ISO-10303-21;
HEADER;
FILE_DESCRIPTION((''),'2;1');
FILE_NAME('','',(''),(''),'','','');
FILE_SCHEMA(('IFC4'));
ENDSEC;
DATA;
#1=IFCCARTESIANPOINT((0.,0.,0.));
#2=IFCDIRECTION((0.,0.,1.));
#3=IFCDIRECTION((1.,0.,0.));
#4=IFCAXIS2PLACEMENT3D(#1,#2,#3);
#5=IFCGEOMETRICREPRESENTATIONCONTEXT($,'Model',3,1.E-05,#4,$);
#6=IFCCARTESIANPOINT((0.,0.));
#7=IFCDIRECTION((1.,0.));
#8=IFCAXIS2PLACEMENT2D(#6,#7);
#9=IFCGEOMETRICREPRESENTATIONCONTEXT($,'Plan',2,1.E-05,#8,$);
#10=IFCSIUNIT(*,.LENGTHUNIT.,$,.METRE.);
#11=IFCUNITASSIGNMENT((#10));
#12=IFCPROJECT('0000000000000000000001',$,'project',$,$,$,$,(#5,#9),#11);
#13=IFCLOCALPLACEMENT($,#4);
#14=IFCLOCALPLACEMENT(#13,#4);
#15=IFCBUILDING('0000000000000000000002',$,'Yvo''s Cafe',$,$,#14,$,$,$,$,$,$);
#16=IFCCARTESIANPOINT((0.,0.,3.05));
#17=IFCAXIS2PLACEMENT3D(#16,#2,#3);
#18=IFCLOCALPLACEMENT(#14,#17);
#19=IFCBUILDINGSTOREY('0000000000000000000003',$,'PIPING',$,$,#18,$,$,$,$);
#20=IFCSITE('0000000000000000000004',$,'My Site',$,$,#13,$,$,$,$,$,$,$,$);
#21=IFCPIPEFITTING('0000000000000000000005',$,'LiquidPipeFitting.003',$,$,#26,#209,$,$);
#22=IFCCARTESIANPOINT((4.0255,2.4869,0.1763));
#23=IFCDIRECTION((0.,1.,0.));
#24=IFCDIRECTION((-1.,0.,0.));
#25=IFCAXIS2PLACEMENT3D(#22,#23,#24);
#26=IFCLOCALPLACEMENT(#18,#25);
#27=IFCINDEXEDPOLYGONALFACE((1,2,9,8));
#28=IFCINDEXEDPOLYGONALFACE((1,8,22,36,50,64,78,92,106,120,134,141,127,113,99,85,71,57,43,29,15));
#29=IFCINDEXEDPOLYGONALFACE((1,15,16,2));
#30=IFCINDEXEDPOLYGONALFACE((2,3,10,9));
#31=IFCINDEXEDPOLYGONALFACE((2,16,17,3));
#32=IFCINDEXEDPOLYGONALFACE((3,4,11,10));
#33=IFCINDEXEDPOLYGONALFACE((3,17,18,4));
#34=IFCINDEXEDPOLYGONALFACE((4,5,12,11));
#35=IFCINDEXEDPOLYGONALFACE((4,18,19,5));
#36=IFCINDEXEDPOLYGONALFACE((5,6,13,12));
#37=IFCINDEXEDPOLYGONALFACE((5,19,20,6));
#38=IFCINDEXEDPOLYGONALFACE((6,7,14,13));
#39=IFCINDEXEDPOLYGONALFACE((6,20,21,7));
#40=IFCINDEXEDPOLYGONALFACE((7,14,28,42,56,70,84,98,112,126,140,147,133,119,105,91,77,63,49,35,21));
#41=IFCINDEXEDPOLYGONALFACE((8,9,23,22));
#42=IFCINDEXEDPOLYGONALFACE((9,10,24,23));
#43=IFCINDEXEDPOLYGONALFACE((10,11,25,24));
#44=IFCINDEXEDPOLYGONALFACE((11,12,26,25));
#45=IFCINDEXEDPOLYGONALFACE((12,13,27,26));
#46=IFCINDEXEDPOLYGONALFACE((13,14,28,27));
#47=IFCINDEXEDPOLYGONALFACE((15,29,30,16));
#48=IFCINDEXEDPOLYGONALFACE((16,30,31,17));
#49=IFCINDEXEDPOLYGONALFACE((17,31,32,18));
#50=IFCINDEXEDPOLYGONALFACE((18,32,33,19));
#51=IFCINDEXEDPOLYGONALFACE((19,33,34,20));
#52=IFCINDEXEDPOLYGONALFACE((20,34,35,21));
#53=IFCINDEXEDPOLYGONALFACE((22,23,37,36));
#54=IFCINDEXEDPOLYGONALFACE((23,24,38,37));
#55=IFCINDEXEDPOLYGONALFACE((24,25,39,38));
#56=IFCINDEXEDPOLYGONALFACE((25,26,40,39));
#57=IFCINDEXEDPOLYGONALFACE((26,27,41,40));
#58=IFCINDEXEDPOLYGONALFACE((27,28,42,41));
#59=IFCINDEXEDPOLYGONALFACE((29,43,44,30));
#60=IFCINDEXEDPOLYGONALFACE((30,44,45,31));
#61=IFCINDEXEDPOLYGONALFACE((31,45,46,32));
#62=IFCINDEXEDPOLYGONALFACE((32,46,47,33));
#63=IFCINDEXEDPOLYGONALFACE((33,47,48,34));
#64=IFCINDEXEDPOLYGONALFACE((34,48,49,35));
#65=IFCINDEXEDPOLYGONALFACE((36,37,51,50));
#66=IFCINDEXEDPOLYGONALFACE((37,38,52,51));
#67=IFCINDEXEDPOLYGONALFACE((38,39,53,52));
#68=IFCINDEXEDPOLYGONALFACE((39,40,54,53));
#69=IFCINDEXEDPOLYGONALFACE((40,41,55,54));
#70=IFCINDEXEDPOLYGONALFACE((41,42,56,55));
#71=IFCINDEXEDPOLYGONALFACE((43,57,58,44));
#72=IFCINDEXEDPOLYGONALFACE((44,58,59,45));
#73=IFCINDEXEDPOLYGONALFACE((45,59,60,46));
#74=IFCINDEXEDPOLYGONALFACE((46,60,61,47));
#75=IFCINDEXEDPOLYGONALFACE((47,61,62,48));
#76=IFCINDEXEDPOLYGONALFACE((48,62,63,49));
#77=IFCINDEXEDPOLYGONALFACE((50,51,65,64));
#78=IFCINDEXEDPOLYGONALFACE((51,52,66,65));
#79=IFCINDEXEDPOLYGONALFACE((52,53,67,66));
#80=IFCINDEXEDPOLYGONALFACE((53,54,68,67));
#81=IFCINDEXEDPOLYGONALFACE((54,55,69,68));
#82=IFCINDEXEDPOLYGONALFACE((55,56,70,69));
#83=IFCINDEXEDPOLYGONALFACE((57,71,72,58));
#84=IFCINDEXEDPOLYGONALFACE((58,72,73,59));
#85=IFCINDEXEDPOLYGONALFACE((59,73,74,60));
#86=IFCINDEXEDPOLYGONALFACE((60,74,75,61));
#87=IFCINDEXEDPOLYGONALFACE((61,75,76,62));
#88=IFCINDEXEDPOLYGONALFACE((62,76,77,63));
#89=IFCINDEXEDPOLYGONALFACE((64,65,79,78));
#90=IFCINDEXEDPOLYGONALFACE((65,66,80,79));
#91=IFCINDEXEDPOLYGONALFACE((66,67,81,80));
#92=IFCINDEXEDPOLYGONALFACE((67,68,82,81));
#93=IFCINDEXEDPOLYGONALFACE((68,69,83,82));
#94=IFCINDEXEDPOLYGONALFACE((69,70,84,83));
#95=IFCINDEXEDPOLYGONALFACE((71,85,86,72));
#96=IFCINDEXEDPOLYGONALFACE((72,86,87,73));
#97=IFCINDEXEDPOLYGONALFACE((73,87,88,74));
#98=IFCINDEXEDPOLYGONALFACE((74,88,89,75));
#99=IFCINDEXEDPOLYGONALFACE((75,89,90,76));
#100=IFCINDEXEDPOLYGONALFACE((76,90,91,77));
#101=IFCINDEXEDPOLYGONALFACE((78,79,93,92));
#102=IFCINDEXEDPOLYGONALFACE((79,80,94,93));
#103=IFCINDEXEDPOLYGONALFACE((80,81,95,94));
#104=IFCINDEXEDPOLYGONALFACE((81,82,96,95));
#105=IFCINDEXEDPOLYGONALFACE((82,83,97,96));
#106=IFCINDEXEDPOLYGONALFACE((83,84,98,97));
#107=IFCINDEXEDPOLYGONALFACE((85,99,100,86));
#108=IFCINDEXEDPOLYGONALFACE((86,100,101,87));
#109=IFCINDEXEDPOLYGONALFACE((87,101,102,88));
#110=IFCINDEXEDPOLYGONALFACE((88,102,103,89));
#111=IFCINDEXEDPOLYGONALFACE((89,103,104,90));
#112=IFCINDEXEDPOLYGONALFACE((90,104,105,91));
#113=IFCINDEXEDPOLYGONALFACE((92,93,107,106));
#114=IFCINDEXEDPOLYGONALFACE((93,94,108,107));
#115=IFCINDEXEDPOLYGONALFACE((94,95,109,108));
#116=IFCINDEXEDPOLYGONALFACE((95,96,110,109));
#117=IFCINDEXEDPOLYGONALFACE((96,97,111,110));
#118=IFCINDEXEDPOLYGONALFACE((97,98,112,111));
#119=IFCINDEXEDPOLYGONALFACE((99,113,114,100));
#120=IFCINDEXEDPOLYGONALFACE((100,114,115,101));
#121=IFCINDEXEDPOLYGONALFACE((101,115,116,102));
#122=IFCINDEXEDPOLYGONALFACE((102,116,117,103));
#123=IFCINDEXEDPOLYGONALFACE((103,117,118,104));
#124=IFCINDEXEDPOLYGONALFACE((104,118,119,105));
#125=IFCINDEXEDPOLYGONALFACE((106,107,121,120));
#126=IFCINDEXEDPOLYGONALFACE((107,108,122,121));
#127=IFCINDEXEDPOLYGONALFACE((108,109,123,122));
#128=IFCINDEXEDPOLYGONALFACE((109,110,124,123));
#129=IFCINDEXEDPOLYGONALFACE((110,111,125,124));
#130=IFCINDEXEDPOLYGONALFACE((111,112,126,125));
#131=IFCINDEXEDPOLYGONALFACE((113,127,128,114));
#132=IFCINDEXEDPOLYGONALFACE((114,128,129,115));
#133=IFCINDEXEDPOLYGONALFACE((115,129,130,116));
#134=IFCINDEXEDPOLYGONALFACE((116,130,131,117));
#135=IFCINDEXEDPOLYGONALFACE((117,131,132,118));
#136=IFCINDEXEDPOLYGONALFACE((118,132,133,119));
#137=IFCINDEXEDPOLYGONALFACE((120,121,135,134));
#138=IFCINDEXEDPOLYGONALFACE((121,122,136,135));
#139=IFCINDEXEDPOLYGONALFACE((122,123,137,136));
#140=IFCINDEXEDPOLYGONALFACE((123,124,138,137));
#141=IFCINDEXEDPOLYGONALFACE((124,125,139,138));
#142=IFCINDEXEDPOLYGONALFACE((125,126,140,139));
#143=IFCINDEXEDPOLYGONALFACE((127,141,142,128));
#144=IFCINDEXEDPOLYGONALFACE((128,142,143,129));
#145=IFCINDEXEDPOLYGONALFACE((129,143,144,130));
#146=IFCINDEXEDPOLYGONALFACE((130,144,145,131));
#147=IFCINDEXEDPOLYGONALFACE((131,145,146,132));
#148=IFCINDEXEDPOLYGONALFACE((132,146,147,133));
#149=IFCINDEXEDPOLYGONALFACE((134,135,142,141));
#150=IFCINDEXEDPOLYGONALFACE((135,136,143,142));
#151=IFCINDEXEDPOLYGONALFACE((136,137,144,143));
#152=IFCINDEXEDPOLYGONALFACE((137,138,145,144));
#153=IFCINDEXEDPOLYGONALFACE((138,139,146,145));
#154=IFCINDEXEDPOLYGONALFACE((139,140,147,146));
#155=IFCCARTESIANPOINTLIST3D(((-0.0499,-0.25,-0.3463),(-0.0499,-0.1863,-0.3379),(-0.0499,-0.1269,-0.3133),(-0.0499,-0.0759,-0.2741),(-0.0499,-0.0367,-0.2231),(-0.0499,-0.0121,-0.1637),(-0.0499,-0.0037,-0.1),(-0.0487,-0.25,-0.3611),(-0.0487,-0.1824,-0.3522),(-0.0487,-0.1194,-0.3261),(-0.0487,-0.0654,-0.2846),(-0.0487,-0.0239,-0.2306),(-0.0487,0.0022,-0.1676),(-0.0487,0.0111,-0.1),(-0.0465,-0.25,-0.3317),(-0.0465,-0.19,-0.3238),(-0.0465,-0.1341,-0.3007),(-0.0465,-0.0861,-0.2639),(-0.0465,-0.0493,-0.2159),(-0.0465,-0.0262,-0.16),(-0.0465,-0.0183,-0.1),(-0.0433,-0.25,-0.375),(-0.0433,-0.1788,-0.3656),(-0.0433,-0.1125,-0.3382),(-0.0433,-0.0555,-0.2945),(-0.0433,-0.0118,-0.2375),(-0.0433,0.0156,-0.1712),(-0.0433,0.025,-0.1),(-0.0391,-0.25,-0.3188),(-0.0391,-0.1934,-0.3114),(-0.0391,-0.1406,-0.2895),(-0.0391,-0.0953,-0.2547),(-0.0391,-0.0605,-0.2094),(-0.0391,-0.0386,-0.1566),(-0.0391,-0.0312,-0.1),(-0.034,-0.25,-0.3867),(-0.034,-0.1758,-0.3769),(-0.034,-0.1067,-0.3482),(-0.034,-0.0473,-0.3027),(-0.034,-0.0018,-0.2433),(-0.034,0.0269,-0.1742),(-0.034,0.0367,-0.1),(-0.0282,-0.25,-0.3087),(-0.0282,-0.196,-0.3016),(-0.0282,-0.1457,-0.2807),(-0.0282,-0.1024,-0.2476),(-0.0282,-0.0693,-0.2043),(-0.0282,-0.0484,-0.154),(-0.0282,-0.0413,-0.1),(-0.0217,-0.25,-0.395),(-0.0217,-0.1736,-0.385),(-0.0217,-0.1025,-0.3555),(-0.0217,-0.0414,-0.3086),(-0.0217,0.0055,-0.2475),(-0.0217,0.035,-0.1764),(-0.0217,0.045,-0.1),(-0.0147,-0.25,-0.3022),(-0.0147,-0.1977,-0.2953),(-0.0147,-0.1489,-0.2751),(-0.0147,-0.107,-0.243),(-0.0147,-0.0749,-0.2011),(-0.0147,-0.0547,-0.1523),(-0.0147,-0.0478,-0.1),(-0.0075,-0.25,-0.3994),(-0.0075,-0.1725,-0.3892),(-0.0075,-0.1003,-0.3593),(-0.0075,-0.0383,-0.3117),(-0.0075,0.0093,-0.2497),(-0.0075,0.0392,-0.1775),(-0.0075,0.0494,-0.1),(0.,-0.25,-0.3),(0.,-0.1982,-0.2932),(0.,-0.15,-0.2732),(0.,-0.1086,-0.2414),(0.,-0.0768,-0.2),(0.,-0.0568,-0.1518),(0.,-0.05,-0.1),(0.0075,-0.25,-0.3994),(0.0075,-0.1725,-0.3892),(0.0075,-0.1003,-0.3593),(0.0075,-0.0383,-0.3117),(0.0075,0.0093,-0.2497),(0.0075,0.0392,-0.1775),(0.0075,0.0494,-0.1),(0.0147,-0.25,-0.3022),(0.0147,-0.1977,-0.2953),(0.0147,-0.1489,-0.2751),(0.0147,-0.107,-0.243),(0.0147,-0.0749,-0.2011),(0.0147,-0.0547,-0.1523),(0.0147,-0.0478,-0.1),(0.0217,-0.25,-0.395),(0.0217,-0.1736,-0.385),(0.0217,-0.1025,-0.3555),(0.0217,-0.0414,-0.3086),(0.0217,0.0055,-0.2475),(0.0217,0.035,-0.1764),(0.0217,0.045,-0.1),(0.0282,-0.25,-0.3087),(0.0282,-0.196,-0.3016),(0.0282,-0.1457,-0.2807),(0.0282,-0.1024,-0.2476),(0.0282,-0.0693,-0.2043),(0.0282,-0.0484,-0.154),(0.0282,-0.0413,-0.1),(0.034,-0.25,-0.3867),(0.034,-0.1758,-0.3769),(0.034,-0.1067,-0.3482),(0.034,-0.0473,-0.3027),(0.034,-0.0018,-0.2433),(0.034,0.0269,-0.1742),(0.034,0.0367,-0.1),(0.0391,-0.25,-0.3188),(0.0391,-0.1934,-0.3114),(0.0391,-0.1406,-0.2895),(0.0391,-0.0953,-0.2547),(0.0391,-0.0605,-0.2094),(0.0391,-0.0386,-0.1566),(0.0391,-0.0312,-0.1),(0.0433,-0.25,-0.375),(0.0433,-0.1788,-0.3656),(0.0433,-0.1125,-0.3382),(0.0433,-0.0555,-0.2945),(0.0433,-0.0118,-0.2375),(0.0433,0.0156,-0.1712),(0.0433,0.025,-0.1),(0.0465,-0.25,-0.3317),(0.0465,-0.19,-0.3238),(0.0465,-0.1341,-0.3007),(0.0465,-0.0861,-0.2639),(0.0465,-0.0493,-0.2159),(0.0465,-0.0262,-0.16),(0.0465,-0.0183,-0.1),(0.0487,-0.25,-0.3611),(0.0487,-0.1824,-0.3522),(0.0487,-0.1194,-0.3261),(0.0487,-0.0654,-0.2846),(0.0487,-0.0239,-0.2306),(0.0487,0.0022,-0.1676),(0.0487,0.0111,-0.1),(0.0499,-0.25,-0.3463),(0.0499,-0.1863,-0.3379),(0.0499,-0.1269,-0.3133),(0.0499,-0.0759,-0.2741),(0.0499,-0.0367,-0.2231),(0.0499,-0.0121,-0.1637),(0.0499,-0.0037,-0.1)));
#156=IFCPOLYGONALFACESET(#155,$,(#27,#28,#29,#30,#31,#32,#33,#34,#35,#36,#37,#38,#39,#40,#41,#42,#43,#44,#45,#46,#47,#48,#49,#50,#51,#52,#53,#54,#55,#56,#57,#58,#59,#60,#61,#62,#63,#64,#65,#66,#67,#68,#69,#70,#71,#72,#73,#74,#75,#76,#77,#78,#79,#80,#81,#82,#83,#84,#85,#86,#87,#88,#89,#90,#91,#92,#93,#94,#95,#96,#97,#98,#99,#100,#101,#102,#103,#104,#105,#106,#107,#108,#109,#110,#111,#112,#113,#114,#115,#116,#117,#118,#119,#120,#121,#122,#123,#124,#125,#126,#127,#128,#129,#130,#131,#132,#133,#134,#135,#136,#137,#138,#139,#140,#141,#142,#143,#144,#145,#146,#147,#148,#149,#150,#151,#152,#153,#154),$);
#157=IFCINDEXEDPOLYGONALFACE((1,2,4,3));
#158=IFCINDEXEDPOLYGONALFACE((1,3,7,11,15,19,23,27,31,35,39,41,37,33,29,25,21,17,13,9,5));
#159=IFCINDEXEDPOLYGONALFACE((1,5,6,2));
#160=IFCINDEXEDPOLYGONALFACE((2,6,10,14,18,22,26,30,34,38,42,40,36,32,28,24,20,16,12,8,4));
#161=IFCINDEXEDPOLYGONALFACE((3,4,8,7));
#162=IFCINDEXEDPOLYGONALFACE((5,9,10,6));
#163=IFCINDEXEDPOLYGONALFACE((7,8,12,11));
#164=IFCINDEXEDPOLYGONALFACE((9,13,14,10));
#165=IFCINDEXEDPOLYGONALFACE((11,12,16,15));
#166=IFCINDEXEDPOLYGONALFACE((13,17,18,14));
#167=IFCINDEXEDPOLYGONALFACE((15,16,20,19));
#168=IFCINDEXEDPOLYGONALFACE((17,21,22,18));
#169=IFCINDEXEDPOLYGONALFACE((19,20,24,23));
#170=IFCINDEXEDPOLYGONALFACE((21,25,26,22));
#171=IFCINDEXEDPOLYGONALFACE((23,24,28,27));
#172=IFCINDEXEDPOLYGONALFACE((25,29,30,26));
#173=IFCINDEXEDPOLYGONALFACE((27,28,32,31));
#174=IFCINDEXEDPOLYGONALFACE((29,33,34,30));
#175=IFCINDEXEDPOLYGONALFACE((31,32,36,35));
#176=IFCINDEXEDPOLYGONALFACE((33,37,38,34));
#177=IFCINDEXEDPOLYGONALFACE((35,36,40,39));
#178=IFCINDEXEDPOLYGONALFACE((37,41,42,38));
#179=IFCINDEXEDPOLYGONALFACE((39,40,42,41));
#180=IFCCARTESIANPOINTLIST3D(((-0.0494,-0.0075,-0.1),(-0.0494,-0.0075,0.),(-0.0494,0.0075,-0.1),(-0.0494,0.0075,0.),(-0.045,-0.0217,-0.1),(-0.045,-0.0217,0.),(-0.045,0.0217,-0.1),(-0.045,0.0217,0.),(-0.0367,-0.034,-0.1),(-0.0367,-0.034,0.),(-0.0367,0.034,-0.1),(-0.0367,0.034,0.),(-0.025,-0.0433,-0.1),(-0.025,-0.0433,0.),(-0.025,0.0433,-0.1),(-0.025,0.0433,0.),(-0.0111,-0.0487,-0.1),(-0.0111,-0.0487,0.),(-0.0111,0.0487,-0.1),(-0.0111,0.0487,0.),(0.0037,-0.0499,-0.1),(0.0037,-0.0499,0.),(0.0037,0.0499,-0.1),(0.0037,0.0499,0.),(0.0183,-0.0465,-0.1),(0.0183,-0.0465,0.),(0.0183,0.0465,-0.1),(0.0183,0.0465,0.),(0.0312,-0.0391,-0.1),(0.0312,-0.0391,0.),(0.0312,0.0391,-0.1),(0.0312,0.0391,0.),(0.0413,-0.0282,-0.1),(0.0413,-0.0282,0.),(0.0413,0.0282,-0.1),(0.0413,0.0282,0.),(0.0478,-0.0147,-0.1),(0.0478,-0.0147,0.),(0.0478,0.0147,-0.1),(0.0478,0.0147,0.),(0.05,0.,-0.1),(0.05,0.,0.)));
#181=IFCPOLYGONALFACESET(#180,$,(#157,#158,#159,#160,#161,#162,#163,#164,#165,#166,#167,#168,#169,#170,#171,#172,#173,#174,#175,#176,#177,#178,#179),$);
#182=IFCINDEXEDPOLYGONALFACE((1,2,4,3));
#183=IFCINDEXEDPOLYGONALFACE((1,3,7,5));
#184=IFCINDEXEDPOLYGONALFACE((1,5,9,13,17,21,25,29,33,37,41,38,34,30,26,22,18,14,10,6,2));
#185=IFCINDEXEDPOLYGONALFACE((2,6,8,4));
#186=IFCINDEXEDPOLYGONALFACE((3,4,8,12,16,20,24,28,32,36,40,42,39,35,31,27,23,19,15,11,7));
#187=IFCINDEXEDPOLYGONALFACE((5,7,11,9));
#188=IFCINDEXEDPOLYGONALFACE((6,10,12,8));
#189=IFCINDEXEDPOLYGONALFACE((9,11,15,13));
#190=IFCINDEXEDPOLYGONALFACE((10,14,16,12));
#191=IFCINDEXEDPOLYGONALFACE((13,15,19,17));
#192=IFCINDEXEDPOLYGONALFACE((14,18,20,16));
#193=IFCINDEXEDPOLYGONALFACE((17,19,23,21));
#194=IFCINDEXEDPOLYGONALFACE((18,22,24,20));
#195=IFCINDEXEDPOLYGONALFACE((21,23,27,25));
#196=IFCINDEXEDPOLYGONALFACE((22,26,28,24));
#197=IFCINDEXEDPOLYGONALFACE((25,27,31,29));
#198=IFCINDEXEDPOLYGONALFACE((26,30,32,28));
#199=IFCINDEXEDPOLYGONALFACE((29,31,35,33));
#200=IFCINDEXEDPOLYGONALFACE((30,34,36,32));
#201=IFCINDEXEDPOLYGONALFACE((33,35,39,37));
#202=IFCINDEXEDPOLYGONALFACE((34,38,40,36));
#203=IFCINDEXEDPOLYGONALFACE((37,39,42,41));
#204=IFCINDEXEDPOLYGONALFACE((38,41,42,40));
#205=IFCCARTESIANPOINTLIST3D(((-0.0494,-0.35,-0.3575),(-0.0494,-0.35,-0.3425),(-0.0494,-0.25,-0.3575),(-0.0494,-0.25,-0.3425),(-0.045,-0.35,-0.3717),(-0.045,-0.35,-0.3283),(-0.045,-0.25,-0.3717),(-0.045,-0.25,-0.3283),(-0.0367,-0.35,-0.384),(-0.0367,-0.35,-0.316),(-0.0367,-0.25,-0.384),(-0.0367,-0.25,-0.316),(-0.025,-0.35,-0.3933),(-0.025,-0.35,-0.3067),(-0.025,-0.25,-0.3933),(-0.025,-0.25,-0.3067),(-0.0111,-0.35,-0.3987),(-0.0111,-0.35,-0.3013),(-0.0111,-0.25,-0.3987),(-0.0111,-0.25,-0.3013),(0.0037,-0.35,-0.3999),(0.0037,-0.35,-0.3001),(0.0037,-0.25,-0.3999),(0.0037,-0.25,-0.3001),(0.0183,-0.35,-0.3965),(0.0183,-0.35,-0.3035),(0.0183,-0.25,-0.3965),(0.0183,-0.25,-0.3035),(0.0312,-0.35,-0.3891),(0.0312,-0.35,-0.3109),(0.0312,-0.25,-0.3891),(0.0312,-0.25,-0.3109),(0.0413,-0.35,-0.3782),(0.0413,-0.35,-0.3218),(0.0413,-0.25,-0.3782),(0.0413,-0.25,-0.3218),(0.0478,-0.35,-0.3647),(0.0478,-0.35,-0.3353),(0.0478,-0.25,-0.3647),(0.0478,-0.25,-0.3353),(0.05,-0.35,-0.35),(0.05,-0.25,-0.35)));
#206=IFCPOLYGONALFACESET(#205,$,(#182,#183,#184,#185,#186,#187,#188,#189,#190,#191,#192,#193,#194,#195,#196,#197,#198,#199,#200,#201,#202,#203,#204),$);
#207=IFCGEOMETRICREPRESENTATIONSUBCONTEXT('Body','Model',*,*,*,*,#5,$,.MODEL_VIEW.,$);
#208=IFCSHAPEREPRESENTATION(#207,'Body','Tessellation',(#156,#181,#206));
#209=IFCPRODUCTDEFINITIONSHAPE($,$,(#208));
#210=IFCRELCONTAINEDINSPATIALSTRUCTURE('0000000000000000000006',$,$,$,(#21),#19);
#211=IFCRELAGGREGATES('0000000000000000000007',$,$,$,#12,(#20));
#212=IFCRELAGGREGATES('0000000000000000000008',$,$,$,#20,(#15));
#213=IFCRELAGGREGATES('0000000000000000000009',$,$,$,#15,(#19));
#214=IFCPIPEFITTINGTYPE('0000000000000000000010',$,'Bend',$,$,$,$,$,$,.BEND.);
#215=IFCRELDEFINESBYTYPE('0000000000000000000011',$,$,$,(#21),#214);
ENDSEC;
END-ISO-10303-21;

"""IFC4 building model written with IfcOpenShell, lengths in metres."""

from ifc_helpers import new_model, entity, si_unit, frame, origin_with_axes, origin_2d_with_axis, place, context, subcontext, project, spatial, circle, extrude, source, transform, mapped, type_object, type_shapes, element, save


model = new_model("IFC4")

# Units and contexts
model_context = context("Model", 3, precision=1e-05, world=origin_with_axes())
plan_context = context("Plan", 2, precision=1e-05, world=origin_2d_with_axis())
body_context = subcontext(model_context, "Body", "Model", "MODEL_VIEW")
ifc_project = project(units=[si_unit("LENGTHUNIT", "METRE")], contexts=[model_context, plan_context])

# Site, building, storey
site_placement = place(None, origin_with_axes())
site = spatial("IfcSite", under=ifc_project, at=site_placement, Name="My Site")
building_placement = place(site_placement, origin_with_axes())
building = spatial("IfcBuilding", under=site, at=building_placement, Name="Yvo's Cafe")
storey_placement = place(building_placement, frame((0.0, 0.0, 3.05), z_axis=(0.0, 0.0, 1.0), x_axis=(1.0, 0.0, 0.0)))
storey = spatial("IfcBuildingStorey", under=building, at=storey_placement, Name="PIPING")

# Shared definitions
pipe_fitting_type_1 = type_object("IfcPipeFittingType", Name="Bend", PredefinedType="BEND")
shared_shape_1 = source(origin_with_axes(), body_context, "Body", "SolidModel", [
    entity("IfcSweptDiskSolid", entity("IfcIndexedPolyCurve", entity("IfcCartesianPointList3D", [[0.0, 0.0, -0.1], [0.0, -0.0732, -0.2768], [0.0, -0.25, -0.35]]), [entity("IfcArcIndex", [1, 2, 3])]), 0.05),
    extrude(circle(Radius=0.05), origin_with_axes(), (0.0, 0.0, -1.0), 0.1),
    extrude(circle(Radius=0.05), frame((0.0, -0.25, -0.35), z_axis=(0.0, -1.0, 0.0), x_axis=(1.0, 0.0, 0.0)), (0.0, 0.0, 1.0), 0.1),
])
type_shapes(pipe_fitting_type_1, [shared_shape_1])

# Pipe fitting
for number, where, z_axis, x_axis, name in (
    (1, (4.0255, 2.4869, 0.1763), (0.0, 1.0, 0.0), (-1.0, 0.0, 0.0), "LiquidPipeFitting.003"),
):
    element("IfcPipeFitting", number, at=place(storey_placement, frame(where, z_axis=z_axis, x_axis=x_axis)), inside=storey, type_object=pipe_fitting_type_1, Name=name, context=body_context, shape_type="MappedRepresentation", body=[
        mapped(shared_shape_1, transform((0.0, 0.0, 0.0), x_axis=(1.0, 0.0, 0.0), y_axis=(0.0, 1.0, 0.0), z_axis=(0.0, 0.0, 1.0), scale=1.0)),
    ])

save(model, "model.ifc")
